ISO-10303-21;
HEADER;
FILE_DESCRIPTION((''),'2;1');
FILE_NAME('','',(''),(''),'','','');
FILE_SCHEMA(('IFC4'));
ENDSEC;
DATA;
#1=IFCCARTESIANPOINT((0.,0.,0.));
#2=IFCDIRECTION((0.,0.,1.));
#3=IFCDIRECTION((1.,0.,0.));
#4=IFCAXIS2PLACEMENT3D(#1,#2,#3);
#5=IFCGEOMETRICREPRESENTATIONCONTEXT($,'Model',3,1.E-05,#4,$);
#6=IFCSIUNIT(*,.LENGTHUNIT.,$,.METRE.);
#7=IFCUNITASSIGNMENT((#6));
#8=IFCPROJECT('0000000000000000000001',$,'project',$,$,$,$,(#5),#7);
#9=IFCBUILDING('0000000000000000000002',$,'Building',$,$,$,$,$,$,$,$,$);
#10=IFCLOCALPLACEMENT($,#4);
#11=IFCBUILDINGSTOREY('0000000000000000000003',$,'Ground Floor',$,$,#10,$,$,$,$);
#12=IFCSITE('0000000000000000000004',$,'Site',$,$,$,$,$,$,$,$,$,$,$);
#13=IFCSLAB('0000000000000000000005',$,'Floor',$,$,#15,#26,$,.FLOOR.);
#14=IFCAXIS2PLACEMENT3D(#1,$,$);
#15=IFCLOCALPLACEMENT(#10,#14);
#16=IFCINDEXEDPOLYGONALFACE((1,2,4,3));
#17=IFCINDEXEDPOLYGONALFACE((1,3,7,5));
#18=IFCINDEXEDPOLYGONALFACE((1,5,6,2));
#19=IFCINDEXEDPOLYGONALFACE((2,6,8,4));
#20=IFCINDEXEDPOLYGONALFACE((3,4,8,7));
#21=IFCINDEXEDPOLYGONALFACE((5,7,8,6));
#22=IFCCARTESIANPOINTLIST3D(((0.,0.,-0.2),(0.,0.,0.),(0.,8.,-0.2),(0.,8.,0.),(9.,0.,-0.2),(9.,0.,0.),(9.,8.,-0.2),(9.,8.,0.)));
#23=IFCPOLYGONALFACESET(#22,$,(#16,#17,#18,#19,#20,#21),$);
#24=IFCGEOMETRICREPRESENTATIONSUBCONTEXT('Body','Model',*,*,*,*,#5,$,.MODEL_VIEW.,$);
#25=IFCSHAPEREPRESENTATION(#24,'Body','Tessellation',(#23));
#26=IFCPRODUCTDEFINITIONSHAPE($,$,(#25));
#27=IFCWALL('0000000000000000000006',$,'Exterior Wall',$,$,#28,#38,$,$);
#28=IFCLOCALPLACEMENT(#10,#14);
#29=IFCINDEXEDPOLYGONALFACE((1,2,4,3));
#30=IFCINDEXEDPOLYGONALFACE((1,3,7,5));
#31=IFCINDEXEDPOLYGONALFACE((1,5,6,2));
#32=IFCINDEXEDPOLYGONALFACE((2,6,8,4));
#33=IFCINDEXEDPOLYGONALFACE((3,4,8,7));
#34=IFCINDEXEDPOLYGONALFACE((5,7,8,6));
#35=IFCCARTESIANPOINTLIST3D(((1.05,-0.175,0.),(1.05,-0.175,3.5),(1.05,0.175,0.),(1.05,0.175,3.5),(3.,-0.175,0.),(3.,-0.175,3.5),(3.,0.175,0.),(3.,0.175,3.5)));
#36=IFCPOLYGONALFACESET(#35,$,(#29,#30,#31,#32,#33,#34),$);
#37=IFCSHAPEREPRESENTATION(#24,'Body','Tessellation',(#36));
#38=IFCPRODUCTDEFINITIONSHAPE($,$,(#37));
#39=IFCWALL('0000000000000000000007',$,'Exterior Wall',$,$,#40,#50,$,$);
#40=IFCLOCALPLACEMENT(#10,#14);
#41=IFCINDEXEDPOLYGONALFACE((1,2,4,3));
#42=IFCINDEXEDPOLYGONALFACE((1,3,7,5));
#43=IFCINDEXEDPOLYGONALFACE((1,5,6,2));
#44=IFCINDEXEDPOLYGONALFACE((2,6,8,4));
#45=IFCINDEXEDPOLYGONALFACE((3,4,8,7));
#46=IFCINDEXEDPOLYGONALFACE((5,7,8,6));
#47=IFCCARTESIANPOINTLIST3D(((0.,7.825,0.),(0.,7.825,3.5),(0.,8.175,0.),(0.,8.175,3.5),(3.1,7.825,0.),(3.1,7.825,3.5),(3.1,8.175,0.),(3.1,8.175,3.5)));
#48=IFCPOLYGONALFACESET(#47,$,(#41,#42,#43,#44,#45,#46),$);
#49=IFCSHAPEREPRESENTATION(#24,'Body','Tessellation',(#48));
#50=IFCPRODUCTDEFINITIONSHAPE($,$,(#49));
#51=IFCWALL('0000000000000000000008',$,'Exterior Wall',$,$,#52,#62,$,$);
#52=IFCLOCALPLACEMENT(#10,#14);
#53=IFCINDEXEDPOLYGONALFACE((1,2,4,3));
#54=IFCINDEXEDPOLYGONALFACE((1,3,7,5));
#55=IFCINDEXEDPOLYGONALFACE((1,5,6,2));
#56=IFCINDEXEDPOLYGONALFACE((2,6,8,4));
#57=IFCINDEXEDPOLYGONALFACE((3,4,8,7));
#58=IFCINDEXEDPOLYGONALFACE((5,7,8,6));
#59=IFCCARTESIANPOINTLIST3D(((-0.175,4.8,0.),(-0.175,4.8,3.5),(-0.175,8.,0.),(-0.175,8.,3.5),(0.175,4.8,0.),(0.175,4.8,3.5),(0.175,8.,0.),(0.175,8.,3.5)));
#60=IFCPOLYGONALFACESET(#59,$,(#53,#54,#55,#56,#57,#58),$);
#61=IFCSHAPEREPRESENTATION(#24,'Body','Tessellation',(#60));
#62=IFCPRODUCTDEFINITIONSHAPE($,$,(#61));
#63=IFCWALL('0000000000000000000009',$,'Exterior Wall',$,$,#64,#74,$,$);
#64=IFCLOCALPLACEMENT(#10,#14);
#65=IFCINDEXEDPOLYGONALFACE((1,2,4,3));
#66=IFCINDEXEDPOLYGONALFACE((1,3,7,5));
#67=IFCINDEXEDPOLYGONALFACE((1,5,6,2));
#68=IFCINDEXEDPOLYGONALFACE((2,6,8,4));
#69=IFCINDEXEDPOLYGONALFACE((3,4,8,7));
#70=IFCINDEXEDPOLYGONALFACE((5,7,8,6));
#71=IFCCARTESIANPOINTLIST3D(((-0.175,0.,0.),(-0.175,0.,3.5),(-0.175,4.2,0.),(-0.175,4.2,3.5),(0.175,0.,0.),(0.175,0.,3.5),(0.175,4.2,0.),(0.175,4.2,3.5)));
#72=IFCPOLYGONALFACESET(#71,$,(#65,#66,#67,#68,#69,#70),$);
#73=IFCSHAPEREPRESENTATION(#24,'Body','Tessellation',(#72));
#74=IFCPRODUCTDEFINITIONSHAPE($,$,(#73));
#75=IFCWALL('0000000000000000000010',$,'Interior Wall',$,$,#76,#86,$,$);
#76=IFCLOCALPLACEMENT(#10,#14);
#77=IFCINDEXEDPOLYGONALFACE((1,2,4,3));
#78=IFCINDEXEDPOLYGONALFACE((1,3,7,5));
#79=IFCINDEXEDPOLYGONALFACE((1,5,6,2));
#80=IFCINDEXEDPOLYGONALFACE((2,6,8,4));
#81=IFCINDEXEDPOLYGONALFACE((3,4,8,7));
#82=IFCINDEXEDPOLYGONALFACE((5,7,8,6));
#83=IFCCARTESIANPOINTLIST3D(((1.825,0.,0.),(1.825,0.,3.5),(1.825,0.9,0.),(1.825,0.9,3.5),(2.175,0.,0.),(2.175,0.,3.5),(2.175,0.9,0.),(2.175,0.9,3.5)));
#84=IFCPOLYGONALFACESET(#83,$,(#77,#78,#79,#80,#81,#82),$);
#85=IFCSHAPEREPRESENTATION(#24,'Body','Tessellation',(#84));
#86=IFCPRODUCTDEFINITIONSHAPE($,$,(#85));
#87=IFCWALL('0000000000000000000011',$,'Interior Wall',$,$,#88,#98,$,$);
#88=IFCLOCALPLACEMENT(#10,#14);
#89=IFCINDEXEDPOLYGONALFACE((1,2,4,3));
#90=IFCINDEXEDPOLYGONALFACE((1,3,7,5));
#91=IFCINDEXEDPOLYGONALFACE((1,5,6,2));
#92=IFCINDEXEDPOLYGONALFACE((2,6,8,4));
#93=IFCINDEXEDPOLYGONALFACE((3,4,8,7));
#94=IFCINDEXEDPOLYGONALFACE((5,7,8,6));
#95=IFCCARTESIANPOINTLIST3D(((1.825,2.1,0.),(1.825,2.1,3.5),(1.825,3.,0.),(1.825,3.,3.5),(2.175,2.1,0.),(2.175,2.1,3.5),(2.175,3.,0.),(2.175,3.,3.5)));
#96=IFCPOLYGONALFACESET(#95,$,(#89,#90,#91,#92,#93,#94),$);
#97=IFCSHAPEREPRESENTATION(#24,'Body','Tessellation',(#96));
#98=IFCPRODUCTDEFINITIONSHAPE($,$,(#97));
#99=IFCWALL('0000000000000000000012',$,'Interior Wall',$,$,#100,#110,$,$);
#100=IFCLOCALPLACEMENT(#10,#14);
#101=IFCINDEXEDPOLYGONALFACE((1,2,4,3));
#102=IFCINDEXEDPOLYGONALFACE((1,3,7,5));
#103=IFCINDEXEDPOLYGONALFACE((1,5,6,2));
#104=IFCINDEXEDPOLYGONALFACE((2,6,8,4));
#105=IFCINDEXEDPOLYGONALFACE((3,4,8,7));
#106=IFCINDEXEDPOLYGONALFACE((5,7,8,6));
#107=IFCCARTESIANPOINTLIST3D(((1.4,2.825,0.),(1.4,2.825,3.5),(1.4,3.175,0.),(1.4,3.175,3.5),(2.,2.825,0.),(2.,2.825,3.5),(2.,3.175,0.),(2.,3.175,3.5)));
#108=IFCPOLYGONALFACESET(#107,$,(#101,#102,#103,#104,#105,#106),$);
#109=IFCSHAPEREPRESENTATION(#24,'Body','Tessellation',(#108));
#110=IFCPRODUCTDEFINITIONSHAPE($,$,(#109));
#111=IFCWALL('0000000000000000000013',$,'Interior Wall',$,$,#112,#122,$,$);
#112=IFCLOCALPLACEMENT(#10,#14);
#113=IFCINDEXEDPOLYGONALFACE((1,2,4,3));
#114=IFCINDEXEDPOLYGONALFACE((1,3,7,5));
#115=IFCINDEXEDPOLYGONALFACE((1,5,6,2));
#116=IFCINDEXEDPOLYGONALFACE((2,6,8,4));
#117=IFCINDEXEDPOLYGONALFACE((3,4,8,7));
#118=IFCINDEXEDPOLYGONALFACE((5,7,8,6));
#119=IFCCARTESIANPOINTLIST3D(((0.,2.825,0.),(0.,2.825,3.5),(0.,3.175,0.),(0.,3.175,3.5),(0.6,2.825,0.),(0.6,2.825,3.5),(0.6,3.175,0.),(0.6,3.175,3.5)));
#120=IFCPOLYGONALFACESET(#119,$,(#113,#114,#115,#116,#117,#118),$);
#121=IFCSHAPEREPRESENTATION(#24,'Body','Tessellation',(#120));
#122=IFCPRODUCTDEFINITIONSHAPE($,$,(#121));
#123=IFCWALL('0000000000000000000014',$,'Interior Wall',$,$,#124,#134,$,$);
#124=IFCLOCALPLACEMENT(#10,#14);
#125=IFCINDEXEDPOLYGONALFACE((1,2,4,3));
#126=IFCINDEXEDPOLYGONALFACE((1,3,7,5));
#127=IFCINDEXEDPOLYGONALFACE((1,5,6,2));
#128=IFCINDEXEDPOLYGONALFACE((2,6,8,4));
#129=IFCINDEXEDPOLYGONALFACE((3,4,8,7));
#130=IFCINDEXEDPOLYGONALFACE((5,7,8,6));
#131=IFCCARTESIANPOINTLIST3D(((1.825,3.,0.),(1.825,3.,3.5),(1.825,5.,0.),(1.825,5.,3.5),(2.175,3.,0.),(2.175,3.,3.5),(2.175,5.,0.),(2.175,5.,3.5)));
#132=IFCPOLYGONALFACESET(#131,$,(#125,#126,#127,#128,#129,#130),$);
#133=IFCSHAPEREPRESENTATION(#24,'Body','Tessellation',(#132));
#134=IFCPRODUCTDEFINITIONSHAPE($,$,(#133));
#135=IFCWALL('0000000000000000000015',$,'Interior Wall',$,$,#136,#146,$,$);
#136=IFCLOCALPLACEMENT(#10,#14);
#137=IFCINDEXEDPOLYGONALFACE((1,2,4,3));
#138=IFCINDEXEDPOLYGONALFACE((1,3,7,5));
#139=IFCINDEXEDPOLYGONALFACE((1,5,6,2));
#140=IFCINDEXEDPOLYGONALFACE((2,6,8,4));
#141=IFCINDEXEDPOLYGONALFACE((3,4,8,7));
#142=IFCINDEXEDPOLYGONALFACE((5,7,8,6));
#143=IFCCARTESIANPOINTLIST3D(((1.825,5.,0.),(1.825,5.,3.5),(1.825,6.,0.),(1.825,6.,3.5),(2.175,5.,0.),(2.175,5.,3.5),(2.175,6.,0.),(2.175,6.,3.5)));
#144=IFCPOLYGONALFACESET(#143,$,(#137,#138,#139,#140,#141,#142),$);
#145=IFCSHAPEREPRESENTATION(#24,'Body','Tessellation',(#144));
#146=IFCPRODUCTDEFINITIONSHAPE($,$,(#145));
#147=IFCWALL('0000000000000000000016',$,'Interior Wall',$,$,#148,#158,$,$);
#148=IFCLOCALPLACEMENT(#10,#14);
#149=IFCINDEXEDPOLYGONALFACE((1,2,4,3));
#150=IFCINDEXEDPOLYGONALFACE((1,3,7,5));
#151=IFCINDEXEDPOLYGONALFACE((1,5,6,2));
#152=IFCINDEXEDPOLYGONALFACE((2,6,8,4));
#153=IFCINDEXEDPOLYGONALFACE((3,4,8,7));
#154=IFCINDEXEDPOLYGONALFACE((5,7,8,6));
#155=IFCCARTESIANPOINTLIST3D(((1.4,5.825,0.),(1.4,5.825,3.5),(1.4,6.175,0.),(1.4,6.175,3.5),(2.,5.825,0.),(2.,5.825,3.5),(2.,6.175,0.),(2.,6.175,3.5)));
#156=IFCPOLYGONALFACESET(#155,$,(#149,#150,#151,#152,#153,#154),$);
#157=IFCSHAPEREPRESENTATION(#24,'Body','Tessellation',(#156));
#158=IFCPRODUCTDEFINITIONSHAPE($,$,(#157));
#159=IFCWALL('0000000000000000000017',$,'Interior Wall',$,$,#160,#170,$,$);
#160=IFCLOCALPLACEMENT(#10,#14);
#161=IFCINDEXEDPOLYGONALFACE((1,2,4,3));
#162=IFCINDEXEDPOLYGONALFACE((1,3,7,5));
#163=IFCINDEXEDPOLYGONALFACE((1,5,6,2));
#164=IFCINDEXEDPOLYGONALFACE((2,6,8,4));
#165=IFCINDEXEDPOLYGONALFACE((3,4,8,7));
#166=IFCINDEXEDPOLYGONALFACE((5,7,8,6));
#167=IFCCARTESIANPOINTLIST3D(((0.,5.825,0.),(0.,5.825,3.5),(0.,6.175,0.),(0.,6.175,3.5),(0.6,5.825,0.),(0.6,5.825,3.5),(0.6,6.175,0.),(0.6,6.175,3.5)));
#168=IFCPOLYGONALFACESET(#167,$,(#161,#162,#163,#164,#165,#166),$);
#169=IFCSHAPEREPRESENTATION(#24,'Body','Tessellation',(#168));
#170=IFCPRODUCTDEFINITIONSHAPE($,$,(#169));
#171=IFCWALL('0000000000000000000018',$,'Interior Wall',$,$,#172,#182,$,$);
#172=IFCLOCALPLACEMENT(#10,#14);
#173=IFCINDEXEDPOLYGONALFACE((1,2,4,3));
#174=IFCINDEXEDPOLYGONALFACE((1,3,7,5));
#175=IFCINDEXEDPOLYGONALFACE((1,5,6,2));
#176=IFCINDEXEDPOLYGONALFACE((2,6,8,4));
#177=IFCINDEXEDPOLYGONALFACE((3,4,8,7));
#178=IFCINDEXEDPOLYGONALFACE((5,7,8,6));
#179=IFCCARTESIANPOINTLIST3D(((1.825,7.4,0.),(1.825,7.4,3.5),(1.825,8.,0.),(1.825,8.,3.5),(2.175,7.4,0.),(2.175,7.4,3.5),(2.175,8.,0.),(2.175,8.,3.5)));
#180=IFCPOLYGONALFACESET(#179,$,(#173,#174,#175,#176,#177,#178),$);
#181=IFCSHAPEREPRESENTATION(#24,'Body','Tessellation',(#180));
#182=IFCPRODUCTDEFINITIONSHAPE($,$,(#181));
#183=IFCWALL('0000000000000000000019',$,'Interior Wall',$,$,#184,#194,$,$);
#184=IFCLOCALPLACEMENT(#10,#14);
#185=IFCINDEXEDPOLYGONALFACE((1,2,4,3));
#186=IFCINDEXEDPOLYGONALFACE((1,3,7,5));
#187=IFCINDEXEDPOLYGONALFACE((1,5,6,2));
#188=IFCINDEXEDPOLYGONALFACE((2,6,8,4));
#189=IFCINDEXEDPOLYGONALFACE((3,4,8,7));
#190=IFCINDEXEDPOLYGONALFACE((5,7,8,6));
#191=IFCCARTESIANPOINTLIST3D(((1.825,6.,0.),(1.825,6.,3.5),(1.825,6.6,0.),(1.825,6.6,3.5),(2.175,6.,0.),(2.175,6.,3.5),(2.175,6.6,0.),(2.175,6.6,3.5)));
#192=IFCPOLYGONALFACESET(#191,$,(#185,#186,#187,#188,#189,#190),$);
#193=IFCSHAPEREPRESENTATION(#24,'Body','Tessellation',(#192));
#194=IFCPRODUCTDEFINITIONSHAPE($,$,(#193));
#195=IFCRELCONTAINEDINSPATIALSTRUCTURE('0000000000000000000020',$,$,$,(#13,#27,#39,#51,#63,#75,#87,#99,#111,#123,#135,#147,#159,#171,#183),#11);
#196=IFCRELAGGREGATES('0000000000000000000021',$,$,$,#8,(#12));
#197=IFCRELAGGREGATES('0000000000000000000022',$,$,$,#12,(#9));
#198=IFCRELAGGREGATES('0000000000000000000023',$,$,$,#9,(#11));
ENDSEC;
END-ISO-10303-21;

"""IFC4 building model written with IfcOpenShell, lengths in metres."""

from ifc_helpers import new_model, si_unit, frame, origin_with_axes, place, context, subcontext, project, spatial, indexed_curve, outline, extrude, element, save


model = new_model("IFC4")

# Units and contexts
model_context = context("Model", 3, precision=1e-05, world=origin_with_axes())
body_context = subcontext(model_context, "Body", "Model", "MODEL_VIEW")
ifc_project = project(units=[si_unit("LENGTHUNIT", "METRE")], contexts=[model_context])

# Site, building, storey
site = spatial("IfcSite", under=ifc_project, Name="Site")
building = spatial("IfcBuilding", under=site, Name="Building")
storey_placement = place(None, origin_with_axes())
storey = spatial("IfcBuildingStorey", under=building, at=storey_placement, Name="Ground Floor")

# Slab
slab_placement = place(storey_placement, frame((0.0, 0.0, -0.2), z_axis=(0.0, 0.0, 1.0), x_axis=(1.0, 0.0, 0.0)))
element("IfcSlab", 1, at=slab_placement, inside=storey, Name="Floor", PredefinedType="FLOOR", context=body_context, shape_type="SweptSolid", body=[
    extrude(outline(indexed_curve([(0.0, 0.0), (9.0, 0.0), (9.0, 8.0), (0.0, 8.0)])), None, (0.0, 0.0, 1.0), 0.2),
])

# Walls
wall_1_placement = place(storey_placement, frame((1.05, 0.0, 0.0), z_axis=(0.0, 0.0, 1.0), x_axis=(1.0, 0.0, 0.0)))
element("IfcWall", 2, at=wall_1_placement, inside=storey, Name="Exterior Wall", context=body_context, shape_type="SweptSolid", body=[
    extrude(outline(indexed_curve([(0.0, 0.0), (0.0, 0.35), (1.95, 0.35), (1.95, 0.0), (0.0, 0.0)], self_intersect=False)), frame((0.0, -0.175, 0.0), z_axis=(0.0, 0.0, 1.0), x_axis=(1.0, 0.0, 0.0)), (0.0, 0.0, 1.0), 3.5),
])
wall_2_placement = place(storey_placement, frame((3.1, 8.0, 0.0), z_axis=(0.0, 0.0, 1.0), x_axis=(-1.0, 0.0, 0.0)))
element("IfcWall", 3, at=wall_2_placement, inside=storey, Name="Exterior Wall", context=body_context, shape_type="SweptSolid", body=[
    extrude(outline(indexed_curve([(0.0, 0.0), (0.0, 0.35), (3.1, 0.35), (3.1, 0.0), (0.0, 0.0)], self_intersect=False)), frame((0.0, -0.175, 0.0), z_axis=(0.0, 0.0, 1.0), x_axis=(1.0, 0.0, 0.0)), (0.0, 0.0, 1.0), 3.5),
])
wall_3_placement = place(storey_placement, frame((0.0, 8.0, 0.0), z_axis=(0.0, 0.0, 1.0), x_axis=(0.0, -1.0, 0.0)))
element("IfcWall", 4, at=wall_3_placement, inside=storey, Name="Exterior Wall", context=body_context, shape_type="SweptSolid", body=[
    extrude(outline(indexed_curve([(0.0, 0.0), (0.0, 0.35), (3.2, 0.35), (3.2, 0.0), (0.0, 0.0)], self_intersect=False)), frame((0.0, -0.175, 0.0), z_axis=(0.0, 0.0, 1.0), x_axis=(1.0, 0.0, 0.0)), (0.0, 0.0, 1.0), 3.5),
])
wall_4_placement = place(storey_placement, frame((0.0, 4.2, 0.0), z_axis=(0.0, 0.0, 1.0), x_axis=(0.0, -1.0, 0.0)))
element("IfcWall", 5, at=wall_4_placement, inside=storey, Name="Exterior Wall", context=body_context, shape_type="SweptSolid", body=[
    extrude(outline(indexed_curve([(0.0, 0.0), (0.0, 0.35), (4.2, 0.35), (4.2, 0.0), (0.0, 0.0)], self_intersect=False)), frame((0.0, -0.175, 0.0), z_axis=(0.0, 0.0, 1.0), x_axis=(1.0, 0.0, 0.0)), (0.0, 0.0, 1.0), 3.5),
])
wall_5_placement = place(storey_placement, frame((2.0, 0.0, 0.0), z_axis=(0.0, 0.0, 1.0), x_axis=(0.0, 1.0, 0.0)))
element("IfcWall", 6, at=wall_5_placement, inside=storey, Name="Interior Wall", context=body_context, shape_type="SweptSolid", body=[
    extrude(outline(indexed_curve([(0.0, 0.0), (0.0, 0.35), (0.9, 0.35), (0.9, 0.0), (0.0, 0.0)], self_intersect=False)), frame((0.0, -0.175, 0.0), z_axis=(0.0, 0.0, 1.0), x_axis=(1.0, 0.0, 0.0)), (0.0, 0.0, 1.0), 3.5),
])
wall_6_placement = place(storey_placement, frame((2.0, 2.1, 0.0), z_axis=(0.0, 0.0, 1.0), x_axis=(0.0, 1.0, 0.0)))
element("IfcWall", 7, at=wall_6_placement, inside=storey, Name="Interior Wall", context=body_context, shape_type="SweptSolid", body=[
    extrude(outline(indexed_curve([(0.0, 0.0), (0.0, 0.35), (0.9, 0.35), (0.9, 0.0), (0.0, 0.0)], self_intersect=False)), frame((0.0, -0.175, 0.0), z_axis=(0.0, 0.0, 1.0), x_axis=(1.0, 0.0, 0.0)), (0.0, 0.0, 1.0), 3.5),
])
for number, where, z_axis, x_axis, name in (
    (8, (2.0, 3.0, 0.0), (0.0, 0.0, 1.0), (-1.0, 0.0, 0.0), "Interior Wall"),
    (9, (0.6, 3.0, 0.0), (0.0, 0.0, 1.0), (-1.0, 0.0, 0.0), "Interior Wall"),
):
    element("IfcWall", number, at=place(storey_placement, frame(where, z_axis=z_axis, x_axis=x_axis)), inside=storey, Name=name, context=body_context, shape_type="SweptSolid", body=[
        extrude(outline(indexed_curve([(0.0, 0.0), (0.0, 0.35), (0.6, 0.35), (0.6, 0.0), (0.0, 0.0)], self_intersect=False)), frame((0.0, -0.175, 0.0), z_axis=(0.0, 0.0, 1.0), x_axis=(1.0, 0.0, 0.0)), (0.0, 0.0, 1.0), 3.5),
    ])
wall_7_placement = place(storey_placement, frame((2.0, 5.0, 0.0), z_axis=(0.0, 0.0, 1.0), x_axis=(0.0, -1.0, 0.0)))
element("IfcWall", 10, at=wall_7_placement, inside=storey, Name="Interior Wall", context=body_context, shape_type="SweptSolid", body=[
    extrude(outline(indexed_curve([(0.0, 0.0), (0.0, 0.35), (2.0, 0.35), (2.0, 0.0), (0.0, 0.0)], self_intersect=False)), frame((0.0, -0.175, 0.0), z_axis=(0.0, 0.0, 1.0), x_axis=(1.0, 0.0, 0.0)), (0.0, 0.0, 1.0), 3.5),
])
wall_8_placement = place(storey_placement, frame((2.0, 5.0, 0.0), z_axis=(0.0, 0.0, 1.0), x_axis=(0.0, 1.0, 0.0)))
element("IfcWall", 11, at=wall_8_placement, inside=storey, Name="Interior Wall", context=body_context, shape_type="SweptSolid", body=[
    extrude(outline(indexed_curve([(0.0, 0.0), (0.0, 0.35), (1.0, 0.35), (1.0, 0.0), (0.0, 0.0)], self_intersect=False)), frame((0.0, -0.175, 0.0), z_axis=(0.0, 0.0, 1.0), x_axis=(1.0, 0.0, 0.0)), (0.0, 0.0, 1.0), 3.5),
])
for number, where, z_axis, x_axis, name in (
    (12, (2.0, 6.0, 0.0), (0.0, 0.0, 1.0), (-1.0, 0.0, 0.0), "Interior Wall"),
    (13, (0.6, 6.0, 0.0), (0.0, 0.0, 1.0), (-1.0, 0.0, 0.0), "Interior Wall"),
):
    element("IfcWall", number, at=place(storey_placement, frame(where, z_axis=z_axis, x_axis=x_axis)), inside=storey, Name=name, context=body_context, shape_type="SweptSolid", body=[
        extrude(outline(indexed_curve([(0.0, 0.0), (0.0, 0.35), (0.6, 0.35), (0.6, 0.0), (0.0, 0.0)], self_intersect=False)), frame((0.0, -0.175, 0.0), z_axis=(0.0, 0.0, 1.0), x_axis=(1.0, 0.0, 0.0)), (0.0, 0.0, 1.0), 3.5),
    ])
for number, where, z_axis, x_axis, name in (
    (14, (2.0, 8.0, 0.0), (0.0, 0.0, 1.0), (0.0, -1.0, 0.0), "Interior Wall"),
    (15, (2.0, 6.6, 0.0), (0.0, 0.0, 1.0), (0.0, -1.0, 0.0), "Interior Wall"),
):
    element("IfcWall", number, at=place(storey_placement, frame(where, z_axis=z_axis, x_axis=x_axis)), inside=storey, Name=name, context=body_context, shape_type="SweptSolid", body=[
        extrude(outline(indexed_curve([(0.0, 0.0), (0.0, 0.35), (0.6, 0.35), (0.6, 0.0), (0.0, 0.0)], self_intersect=False)), frame((0.0, -0.175, 0.0), z_axis=(0.0, 0.0, 1.0), x_axis=(1.0, 0.0, 0.0)), (0.0, 0.0, 1.0), 3.5),
    ])

save(model, "model.ifc")
